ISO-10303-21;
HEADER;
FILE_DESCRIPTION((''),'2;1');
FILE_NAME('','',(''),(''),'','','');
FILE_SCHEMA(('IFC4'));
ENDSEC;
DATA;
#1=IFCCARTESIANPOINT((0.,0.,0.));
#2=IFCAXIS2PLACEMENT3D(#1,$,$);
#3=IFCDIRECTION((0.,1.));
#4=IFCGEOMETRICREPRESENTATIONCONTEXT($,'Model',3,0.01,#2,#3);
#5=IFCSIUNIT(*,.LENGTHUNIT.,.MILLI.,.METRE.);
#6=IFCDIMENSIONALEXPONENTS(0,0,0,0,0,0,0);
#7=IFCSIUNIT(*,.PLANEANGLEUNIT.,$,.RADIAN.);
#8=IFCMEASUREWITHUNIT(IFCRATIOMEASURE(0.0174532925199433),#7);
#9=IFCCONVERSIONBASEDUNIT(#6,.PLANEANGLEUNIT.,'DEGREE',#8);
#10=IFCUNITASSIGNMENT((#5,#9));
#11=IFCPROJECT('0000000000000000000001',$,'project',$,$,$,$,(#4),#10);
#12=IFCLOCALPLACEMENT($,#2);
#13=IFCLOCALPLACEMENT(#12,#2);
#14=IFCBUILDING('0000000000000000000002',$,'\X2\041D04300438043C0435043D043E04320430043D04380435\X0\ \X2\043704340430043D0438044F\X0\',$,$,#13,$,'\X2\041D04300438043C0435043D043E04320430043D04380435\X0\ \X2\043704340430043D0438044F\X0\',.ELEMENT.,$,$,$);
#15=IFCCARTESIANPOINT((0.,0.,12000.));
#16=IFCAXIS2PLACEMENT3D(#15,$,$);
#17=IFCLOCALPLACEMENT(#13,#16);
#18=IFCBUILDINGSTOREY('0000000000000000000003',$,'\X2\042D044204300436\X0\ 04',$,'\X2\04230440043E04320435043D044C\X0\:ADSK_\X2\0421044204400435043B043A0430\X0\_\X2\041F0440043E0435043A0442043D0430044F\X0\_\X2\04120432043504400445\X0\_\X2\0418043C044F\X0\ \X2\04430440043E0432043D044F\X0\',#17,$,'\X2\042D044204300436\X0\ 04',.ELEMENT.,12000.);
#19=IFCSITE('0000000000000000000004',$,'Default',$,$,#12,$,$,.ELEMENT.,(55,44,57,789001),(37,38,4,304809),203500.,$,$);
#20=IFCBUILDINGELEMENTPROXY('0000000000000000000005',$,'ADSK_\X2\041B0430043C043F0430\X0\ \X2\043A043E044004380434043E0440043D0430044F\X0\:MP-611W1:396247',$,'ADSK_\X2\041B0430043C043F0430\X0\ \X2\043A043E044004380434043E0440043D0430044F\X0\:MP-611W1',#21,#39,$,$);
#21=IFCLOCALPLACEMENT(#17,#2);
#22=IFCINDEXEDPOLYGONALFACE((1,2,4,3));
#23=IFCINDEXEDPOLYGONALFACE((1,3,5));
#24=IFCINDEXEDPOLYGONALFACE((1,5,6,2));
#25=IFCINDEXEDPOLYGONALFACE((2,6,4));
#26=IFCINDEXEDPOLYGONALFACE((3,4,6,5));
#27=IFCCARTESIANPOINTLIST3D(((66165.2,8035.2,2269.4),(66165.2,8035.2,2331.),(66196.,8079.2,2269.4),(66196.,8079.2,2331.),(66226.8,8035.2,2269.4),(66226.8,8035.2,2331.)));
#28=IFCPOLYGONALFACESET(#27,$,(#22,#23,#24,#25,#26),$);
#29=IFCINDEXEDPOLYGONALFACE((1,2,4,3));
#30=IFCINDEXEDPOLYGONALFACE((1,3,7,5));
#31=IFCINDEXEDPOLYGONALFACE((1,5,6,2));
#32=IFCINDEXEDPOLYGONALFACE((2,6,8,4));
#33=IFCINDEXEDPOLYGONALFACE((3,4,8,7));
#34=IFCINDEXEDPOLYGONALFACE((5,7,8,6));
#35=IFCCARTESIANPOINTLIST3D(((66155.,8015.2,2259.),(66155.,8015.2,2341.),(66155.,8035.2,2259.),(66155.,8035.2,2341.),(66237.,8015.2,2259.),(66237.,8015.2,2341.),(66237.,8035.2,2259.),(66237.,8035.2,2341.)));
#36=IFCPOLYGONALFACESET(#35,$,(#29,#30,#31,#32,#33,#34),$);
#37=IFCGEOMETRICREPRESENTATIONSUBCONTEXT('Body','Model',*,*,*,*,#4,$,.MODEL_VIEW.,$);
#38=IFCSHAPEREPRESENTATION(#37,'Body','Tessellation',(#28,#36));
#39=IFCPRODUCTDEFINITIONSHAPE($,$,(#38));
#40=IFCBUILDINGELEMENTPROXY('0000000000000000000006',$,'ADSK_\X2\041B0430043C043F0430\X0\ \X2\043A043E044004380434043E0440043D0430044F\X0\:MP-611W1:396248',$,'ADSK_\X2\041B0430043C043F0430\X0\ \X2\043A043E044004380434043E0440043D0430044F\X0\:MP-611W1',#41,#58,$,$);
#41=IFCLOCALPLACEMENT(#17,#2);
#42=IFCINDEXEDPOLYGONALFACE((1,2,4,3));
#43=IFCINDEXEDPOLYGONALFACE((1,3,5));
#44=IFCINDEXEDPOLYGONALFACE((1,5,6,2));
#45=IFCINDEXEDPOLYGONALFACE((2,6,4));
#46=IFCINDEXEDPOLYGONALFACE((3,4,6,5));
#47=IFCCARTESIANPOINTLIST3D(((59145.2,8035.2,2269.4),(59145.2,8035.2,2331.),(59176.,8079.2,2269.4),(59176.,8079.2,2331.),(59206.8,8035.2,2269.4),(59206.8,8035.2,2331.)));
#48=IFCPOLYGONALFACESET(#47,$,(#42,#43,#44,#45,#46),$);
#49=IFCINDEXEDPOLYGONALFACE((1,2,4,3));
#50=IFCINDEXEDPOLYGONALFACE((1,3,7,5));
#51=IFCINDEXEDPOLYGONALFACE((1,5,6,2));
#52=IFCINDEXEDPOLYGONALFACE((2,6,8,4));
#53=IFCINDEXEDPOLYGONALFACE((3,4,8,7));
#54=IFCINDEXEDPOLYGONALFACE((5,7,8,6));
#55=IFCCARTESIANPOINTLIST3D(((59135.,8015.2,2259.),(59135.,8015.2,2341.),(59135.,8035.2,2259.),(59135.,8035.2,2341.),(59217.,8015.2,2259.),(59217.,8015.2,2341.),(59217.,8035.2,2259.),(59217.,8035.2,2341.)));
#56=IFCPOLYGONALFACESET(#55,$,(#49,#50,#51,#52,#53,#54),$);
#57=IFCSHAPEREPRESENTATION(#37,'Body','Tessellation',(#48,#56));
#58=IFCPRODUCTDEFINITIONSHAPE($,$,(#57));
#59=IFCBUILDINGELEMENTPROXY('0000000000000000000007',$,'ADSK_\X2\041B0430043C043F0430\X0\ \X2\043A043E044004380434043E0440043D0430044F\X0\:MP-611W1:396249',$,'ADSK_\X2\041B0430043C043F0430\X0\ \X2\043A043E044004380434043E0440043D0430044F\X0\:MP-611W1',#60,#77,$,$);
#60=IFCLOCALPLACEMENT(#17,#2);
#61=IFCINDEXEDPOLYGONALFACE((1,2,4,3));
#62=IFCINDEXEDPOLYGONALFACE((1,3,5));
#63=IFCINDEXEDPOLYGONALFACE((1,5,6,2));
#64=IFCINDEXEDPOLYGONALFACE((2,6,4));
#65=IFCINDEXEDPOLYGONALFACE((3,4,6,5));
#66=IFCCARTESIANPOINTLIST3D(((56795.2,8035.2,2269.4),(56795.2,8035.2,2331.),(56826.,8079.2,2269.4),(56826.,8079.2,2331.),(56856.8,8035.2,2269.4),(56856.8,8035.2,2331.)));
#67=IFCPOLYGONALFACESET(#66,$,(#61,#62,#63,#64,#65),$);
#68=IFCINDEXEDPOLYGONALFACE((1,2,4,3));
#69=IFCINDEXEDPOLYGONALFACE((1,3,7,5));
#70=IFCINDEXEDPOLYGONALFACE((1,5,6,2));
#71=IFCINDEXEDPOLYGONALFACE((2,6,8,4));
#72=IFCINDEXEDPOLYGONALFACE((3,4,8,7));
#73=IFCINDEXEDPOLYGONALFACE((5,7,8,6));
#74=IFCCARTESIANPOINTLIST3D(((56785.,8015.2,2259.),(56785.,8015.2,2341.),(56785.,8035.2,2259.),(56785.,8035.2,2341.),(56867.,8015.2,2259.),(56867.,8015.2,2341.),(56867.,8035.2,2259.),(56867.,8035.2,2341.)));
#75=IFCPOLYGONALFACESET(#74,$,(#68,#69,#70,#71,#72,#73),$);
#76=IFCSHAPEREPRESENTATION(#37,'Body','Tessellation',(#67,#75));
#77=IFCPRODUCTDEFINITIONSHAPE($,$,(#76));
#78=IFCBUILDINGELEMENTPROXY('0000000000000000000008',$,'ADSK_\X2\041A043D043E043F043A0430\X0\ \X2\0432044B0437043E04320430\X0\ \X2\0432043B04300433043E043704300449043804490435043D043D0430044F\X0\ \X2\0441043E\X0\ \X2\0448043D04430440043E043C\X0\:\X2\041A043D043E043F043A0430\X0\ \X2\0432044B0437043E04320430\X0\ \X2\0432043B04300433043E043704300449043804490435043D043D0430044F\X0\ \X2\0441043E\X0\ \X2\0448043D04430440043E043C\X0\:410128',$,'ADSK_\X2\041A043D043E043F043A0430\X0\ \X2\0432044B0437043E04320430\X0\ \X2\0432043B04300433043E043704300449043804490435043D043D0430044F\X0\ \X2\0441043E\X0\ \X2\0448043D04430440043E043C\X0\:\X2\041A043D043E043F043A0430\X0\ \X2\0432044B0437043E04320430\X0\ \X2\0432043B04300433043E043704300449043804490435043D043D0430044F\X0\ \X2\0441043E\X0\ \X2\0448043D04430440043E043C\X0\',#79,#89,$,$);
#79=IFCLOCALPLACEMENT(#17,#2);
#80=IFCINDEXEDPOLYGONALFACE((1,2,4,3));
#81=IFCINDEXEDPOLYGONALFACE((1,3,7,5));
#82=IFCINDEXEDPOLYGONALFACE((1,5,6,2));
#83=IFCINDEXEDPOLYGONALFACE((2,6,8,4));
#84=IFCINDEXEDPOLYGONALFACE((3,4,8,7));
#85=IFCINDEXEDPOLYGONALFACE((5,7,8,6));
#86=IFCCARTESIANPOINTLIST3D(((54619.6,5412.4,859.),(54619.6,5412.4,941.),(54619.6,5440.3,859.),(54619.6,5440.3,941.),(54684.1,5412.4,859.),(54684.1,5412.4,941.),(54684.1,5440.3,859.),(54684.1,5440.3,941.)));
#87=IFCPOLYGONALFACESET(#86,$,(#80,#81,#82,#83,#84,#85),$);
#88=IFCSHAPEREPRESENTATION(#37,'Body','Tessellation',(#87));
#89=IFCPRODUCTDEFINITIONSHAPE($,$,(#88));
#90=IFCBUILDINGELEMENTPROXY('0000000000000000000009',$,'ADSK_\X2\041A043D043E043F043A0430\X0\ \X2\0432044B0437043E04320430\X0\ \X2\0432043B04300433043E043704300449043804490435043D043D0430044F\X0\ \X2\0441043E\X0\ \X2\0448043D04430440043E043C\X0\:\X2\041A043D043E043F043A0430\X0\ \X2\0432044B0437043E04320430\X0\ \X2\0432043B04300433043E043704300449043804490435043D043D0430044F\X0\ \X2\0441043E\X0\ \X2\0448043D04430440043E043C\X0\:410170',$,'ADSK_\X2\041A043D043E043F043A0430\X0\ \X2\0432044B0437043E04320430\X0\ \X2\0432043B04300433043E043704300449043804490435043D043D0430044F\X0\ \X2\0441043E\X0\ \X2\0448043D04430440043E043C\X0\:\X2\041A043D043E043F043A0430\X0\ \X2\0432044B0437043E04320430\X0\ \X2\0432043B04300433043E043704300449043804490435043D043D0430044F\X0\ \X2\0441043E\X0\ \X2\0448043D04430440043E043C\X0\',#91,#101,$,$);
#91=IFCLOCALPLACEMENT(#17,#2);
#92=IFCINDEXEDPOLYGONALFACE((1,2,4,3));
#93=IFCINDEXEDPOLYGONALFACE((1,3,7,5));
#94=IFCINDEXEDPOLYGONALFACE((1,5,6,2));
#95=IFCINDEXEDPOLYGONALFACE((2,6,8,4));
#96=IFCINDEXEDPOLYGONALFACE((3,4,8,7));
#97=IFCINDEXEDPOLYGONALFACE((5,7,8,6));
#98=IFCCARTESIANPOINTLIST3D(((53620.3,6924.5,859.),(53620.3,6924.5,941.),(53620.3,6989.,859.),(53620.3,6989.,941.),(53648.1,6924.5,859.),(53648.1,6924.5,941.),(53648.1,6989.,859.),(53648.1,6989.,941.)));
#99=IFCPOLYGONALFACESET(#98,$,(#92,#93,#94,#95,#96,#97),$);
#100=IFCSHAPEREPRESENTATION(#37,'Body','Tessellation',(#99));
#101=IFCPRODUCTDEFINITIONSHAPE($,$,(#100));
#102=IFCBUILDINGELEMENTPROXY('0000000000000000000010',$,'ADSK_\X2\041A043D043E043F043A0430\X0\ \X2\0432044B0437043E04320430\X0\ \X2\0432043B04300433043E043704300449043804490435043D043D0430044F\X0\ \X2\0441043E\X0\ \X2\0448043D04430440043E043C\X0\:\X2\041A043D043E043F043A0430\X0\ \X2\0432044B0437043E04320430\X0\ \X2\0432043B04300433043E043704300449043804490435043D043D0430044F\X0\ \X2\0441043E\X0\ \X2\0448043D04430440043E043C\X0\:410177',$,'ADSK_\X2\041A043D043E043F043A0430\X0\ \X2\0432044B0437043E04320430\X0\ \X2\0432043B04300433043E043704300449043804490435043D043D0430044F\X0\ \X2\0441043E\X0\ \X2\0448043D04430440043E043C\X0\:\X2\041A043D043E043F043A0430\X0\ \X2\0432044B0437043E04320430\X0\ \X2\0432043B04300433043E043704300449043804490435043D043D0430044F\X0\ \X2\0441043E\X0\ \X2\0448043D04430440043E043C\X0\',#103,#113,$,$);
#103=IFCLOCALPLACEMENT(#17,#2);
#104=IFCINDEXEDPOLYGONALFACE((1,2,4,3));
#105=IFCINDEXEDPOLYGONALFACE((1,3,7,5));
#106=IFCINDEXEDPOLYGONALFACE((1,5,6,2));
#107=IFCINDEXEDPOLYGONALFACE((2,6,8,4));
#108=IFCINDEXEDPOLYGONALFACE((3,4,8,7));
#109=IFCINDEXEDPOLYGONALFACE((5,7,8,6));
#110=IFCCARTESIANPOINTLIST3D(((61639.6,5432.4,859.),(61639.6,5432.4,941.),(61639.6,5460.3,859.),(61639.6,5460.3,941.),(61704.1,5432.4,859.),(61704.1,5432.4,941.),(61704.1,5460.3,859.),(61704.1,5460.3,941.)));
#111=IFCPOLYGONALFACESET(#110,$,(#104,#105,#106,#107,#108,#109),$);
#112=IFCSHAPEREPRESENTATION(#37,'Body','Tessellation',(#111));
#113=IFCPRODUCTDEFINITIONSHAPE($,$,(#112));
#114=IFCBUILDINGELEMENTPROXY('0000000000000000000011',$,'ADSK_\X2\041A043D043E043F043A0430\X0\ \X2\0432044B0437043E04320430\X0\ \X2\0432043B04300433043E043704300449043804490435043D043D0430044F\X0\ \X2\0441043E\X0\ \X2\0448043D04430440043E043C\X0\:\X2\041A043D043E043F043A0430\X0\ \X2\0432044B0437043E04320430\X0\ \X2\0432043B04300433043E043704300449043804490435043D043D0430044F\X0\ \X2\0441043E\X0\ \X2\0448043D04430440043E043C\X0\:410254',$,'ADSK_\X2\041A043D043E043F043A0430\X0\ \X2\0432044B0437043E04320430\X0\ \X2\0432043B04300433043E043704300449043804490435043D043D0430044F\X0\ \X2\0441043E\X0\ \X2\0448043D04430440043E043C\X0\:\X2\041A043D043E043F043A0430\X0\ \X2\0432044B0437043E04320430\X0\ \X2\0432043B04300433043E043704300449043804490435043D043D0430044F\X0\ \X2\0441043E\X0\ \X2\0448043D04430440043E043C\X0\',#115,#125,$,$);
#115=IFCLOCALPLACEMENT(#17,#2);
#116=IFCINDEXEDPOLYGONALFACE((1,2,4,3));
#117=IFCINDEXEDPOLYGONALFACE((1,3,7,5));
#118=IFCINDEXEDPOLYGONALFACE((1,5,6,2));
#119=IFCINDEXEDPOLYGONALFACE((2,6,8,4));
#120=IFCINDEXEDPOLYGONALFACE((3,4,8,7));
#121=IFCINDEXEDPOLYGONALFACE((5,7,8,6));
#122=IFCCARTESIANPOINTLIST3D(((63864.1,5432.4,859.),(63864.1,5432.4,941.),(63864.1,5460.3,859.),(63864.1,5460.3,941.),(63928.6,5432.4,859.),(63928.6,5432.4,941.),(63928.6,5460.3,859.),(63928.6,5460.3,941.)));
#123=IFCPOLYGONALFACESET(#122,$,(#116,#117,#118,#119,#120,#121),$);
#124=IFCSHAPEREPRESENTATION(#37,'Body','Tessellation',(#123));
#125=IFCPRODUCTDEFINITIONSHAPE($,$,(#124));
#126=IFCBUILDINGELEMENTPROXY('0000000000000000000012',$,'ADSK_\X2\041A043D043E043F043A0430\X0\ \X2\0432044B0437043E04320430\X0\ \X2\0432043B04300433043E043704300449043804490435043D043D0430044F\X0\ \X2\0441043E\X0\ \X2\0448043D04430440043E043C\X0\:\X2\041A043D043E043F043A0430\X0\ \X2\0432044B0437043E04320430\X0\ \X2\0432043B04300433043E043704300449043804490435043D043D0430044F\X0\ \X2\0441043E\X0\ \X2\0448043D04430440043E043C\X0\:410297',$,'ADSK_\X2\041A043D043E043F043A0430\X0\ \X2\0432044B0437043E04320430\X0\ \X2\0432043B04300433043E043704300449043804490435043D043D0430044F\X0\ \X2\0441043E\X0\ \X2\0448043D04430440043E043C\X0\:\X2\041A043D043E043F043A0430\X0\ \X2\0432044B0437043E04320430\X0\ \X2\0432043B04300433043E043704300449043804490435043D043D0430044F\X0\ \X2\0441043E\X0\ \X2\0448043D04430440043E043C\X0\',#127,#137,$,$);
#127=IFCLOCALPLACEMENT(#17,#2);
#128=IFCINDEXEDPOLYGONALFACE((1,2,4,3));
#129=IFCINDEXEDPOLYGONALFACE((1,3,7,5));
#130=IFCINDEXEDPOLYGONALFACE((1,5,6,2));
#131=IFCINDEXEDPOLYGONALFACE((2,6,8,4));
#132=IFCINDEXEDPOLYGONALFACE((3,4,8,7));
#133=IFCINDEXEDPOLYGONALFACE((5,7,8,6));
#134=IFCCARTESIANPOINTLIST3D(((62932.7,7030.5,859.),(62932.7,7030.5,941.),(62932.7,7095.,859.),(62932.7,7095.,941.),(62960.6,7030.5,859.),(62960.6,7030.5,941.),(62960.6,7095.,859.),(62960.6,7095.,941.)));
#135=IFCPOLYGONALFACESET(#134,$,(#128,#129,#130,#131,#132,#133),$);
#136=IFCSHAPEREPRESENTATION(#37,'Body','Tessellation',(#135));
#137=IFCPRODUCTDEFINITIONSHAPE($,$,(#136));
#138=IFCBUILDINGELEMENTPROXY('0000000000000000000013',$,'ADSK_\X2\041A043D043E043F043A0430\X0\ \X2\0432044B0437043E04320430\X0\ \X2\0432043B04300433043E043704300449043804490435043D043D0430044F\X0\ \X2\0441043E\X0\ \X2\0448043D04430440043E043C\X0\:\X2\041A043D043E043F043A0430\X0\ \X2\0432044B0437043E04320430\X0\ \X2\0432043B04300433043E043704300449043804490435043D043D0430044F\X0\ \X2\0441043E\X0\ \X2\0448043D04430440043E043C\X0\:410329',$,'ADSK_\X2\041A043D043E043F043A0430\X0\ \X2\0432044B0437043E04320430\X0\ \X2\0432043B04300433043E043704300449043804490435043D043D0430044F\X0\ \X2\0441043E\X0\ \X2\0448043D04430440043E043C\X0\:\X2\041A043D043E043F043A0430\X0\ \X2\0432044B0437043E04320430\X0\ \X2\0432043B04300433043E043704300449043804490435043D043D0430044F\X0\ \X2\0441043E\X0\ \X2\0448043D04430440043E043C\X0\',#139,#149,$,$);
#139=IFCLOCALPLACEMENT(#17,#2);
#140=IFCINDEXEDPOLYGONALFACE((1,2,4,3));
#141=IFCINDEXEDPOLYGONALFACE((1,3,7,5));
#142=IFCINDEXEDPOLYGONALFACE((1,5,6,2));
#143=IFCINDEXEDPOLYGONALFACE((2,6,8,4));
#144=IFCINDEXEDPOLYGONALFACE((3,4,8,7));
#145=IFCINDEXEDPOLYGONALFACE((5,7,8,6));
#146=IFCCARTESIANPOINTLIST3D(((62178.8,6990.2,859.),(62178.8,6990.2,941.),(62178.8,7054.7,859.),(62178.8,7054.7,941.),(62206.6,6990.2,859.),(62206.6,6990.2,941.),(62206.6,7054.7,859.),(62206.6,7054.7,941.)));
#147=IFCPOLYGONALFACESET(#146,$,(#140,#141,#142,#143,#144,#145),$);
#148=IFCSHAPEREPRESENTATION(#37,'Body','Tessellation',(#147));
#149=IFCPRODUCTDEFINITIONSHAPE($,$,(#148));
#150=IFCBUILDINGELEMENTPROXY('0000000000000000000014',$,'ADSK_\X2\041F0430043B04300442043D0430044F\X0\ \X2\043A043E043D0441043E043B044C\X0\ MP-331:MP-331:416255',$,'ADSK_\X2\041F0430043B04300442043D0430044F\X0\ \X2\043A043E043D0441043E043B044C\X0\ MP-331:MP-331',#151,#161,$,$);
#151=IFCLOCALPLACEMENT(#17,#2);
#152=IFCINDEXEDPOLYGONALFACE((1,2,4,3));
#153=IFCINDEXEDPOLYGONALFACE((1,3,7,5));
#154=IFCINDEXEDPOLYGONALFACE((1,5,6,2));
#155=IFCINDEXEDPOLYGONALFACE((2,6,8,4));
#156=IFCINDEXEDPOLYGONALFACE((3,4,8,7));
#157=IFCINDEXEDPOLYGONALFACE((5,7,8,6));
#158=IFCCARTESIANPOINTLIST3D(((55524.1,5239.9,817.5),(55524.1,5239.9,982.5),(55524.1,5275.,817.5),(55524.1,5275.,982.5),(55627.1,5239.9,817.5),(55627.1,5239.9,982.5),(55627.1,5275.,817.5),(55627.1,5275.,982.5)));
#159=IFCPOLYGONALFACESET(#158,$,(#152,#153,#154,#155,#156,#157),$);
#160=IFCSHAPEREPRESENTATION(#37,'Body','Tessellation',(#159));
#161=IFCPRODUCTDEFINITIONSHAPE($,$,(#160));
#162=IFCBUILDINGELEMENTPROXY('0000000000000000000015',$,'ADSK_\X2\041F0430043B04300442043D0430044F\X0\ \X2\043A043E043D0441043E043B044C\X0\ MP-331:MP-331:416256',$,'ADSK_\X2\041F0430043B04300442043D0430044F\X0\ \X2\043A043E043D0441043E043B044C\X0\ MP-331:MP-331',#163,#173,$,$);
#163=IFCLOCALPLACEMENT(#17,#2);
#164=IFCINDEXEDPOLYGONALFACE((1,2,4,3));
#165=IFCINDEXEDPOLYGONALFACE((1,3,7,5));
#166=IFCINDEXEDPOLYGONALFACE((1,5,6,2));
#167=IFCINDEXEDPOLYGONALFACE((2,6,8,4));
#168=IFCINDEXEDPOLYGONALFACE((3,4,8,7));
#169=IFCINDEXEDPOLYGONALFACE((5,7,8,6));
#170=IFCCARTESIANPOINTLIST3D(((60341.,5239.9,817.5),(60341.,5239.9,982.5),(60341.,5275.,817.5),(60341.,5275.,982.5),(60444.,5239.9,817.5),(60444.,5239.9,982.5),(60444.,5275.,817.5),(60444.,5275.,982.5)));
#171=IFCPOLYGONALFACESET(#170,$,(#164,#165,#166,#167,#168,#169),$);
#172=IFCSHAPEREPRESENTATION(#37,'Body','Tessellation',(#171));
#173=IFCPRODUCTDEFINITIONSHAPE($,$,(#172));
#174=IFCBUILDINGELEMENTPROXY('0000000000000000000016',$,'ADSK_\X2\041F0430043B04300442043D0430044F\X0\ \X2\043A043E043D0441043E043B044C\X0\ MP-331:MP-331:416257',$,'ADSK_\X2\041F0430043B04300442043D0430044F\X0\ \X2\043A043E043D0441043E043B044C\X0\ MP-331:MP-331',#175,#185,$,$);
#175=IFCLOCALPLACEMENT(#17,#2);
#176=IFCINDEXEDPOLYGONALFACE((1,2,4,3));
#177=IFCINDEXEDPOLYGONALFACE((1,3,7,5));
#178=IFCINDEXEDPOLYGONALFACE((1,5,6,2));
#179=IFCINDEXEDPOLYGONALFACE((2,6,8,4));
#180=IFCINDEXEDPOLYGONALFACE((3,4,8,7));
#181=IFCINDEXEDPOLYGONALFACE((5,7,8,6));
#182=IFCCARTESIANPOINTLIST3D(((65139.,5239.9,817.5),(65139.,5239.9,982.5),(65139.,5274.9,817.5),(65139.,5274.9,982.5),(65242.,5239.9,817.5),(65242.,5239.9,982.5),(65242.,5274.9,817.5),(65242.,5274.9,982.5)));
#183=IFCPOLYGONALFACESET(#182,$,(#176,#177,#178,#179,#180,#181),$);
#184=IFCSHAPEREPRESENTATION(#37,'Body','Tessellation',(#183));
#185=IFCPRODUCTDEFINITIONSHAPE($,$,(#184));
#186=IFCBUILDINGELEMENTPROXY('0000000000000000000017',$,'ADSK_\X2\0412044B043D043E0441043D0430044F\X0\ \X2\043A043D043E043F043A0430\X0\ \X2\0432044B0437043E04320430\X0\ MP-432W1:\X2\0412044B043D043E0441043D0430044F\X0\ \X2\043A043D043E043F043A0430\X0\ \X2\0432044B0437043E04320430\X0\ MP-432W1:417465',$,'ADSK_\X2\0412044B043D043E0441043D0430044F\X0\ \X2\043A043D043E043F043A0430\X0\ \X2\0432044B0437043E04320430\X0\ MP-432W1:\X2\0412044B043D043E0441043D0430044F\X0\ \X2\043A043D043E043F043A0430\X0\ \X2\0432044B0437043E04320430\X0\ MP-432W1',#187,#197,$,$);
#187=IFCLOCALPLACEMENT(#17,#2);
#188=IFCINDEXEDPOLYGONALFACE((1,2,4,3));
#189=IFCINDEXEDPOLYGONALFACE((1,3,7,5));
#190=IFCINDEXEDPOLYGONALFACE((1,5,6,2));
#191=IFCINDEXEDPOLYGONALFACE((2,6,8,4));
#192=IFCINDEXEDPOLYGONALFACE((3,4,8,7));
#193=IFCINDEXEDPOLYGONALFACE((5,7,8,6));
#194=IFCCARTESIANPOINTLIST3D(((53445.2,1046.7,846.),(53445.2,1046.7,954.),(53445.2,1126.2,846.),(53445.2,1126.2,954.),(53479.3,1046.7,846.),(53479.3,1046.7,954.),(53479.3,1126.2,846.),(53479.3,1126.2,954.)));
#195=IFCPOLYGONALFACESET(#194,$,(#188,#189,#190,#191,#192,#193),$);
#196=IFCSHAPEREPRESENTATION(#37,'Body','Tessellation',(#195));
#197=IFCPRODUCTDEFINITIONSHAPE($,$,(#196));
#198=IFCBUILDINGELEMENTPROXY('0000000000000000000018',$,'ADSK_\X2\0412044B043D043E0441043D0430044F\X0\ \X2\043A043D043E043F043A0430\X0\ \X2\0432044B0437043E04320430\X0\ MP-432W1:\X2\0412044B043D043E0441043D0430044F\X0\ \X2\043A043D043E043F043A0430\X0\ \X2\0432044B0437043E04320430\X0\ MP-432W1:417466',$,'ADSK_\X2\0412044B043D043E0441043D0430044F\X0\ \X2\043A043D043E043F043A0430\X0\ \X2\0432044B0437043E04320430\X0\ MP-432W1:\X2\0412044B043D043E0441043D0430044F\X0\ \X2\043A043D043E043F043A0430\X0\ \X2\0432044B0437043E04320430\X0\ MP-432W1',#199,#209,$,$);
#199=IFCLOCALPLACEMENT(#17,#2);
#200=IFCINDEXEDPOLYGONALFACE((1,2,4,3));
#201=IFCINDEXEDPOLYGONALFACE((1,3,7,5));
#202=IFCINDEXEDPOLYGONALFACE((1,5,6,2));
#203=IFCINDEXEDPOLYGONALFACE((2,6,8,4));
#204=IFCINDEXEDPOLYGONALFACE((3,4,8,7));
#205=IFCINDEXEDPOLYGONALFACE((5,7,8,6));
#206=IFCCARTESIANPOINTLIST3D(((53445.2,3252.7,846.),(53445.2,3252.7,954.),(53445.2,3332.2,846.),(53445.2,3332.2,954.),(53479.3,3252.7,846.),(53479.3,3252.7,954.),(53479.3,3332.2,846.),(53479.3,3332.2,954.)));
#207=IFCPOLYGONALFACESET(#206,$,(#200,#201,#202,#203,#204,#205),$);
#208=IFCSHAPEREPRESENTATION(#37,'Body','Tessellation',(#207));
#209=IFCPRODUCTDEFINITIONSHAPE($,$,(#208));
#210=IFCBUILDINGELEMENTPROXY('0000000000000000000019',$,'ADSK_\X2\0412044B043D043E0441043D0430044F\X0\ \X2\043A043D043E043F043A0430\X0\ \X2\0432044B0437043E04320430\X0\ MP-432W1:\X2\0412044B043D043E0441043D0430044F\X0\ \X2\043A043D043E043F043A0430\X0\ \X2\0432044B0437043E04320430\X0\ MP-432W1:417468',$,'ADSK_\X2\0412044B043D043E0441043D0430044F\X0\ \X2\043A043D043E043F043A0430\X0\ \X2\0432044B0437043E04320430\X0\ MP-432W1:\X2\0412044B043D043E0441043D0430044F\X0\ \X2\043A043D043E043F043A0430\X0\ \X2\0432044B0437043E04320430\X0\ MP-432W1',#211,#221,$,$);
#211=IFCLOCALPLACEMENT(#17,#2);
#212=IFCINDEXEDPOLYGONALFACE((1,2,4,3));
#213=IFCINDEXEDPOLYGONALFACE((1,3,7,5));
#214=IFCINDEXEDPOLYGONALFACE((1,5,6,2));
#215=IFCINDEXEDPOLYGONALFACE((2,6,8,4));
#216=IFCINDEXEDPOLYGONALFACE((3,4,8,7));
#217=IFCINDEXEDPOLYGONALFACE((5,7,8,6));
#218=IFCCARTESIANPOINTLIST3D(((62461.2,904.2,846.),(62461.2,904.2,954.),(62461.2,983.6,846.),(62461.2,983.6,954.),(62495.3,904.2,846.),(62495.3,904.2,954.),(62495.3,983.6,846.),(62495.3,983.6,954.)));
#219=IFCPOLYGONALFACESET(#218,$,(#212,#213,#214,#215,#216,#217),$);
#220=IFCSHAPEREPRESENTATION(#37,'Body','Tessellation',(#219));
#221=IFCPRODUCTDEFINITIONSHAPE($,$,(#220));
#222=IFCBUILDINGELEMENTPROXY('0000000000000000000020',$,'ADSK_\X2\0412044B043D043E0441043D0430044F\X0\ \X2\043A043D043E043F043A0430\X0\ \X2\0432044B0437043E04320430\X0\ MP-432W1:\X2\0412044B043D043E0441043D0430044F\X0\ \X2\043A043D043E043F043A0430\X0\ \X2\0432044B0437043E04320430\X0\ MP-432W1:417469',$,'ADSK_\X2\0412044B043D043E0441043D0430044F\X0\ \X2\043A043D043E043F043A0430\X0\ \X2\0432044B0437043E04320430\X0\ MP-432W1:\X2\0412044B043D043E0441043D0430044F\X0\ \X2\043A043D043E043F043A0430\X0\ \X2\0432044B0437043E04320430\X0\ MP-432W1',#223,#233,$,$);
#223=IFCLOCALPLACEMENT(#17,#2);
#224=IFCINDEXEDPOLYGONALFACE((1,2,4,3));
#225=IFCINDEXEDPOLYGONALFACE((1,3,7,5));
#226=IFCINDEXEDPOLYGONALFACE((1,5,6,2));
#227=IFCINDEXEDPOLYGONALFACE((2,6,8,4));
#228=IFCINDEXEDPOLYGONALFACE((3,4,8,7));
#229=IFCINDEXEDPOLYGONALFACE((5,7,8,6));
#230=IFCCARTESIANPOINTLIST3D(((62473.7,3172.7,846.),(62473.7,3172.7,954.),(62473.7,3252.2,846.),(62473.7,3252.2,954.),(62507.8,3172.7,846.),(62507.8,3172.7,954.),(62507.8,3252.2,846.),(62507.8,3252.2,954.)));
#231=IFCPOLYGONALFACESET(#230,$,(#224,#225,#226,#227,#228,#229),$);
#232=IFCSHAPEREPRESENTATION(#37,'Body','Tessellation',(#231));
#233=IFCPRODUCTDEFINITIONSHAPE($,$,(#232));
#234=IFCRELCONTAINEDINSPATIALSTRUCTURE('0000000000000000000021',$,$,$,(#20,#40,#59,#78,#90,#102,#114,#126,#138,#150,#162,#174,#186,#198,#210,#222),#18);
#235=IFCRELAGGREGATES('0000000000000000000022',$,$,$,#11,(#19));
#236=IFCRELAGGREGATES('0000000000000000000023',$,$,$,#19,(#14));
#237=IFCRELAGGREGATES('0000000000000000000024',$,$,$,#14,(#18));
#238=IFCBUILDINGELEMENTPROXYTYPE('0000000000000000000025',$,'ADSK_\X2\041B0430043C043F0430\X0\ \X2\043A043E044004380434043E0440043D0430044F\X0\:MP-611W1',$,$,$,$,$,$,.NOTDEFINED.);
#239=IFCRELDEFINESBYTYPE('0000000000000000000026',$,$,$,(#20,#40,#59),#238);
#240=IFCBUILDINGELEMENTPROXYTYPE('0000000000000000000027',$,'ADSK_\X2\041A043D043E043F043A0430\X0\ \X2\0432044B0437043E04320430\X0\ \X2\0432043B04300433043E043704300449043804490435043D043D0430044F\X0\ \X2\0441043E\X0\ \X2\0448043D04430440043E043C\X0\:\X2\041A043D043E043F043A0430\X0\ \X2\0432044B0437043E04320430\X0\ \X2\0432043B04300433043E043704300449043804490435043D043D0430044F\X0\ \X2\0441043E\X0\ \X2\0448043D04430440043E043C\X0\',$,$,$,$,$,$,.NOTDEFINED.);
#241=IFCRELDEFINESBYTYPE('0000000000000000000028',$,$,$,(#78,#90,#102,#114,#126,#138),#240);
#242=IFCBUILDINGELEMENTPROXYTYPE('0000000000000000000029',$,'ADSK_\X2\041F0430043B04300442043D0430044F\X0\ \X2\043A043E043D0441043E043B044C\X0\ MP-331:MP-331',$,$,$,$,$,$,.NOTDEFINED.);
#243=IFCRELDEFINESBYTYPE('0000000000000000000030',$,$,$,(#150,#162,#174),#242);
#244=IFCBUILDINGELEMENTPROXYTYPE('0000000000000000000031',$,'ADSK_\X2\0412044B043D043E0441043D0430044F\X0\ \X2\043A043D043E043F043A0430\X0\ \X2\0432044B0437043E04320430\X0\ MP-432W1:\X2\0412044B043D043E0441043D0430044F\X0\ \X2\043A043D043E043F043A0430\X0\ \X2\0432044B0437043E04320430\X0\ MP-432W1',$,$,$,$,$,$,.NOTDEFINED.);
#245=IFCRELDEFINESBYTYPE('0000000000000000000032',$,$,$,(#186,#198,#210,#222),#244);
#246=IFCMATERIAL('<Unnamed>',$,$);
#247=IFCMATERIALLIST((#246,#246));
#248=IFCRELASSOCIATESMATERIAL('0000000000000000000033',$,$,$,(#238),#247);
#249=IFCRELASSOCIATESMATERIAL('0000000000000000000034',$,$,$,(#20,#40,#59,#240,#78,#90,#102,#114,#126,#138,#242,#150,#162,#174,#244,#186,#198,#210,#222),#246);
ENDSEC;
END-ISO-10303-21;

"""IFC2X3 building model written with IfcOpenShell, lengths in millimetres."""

from ifc_helpers import new_model, entity, si_unit, converted_unit, direction, frame, origin, origin_2d_with_axis, place, context, subcontext, project, spatial, polyline, rectangle, outline, extrude, source, transform, mapped, material, material_list, type_object, type_shapes, element, save


model = new_model("IFC2X3")

# Units and contexts
model_context = context("Model", 3, precision=0.01, world=origin(), true_north=direction((0.0, 1.0)))
body_context = subcontext(model_context, "Body", "Model", "MODEL_VIEW")
ifc_project = project(units=[si_unit("LENGTHUNIT", "METRE", prefix="MILLI"), converted_unit("PLANEANGLEUNIT", "DEGREE", entity("IfcRatioMeasure", 0.0174532925199433), si_unit("PLANEANGLEUNIT", "RADIAN"), dimensions=[0, 0, 0, 0, 0, 0, 0])], contexts=[model_context])

# Site, building, storey
site_placement = place(None, origin())
site = spatial("IfcSite", under=ifc_project, at=site_placement, Name="Default", CompositionType="ELEMENT", RefLatitude=(55, 44, 57, 789001), RefLongitude=(37, 38, 4, 304809), RefElevation=203500.0)
building_placement = place(site_placement, origin())
building = spatial("IfcBuilding", under=site, at=building_placement, Name="Наименование здания", LongName="Наименование здания", CompositionType="ELEMENT")
storey_placement = place(building_placement, frame((0.0, 0.0, 12000.0)))
storey = spatial("IfcBuildingStorey", under=building, at=storey_placement, Name="Этаж 04", ObjectType="Уровень:ADSK_Стрелка_Проектная_Вверх_Имя уровня", LongName="Этаж 04", CompositionType="ELEMENT", Elevation=12000.0)

# Building element proxies
ifc_material = material(Name="<Unnamed>")
ifc_material_list = material_list([ifc_material, ifc_material])
building_element_proxy_type_1 = type_object("IfcBuildingElementProxyType", Name="ADSK_Лампа коридорная:MP-611W1", PredefinedType="NOTDEFINED", material=ifc_material_list)
shared_shape_1 = source(origin(), body_context, "Body", "SweptSolid", [
    extrude(outline(polyline([(-30.8, -14.7), (30.8, -14.7), (0.0, 29.3), (-30.8, -14.7)])), frame((0.0, -2.7, -30.6), z_axis=(0.0, 0.0, 1.0), x_axis=(-1.0, 0.0, 0.0)), (0.0, 0.0, 1.0), 61.6),
    extrude(rectangle(XDim=82.0, YDim=20.0, at=origin_2d_with_axis()), frame((0.0, 22.0, -41.0), z_axis=(0.0, 0.0, 1.0), x_axis=(-1.0, 0.0, 0.0)), (0.0, 0.0, 1.0), 82.0),
])
type_shapes(building_element_proxy_type_1, [shared_shape_1])
for number, where, z_axis, x_axis, name in (
    (1, (66196.0, 8047.1, 2300.0), (0.0, 0.0, 1.0), (-1.0, 0.0, 0.0), "ADSK_Лампа коридорная:MP-611W1:396247"),
    (2, (59176.0, 8047.1, 2300.0), (0.0, 0.0, 1.0), (-1.0, 0.0, 0.0), "ADSK_Лампа коридорная:MP-611W1:396248"),
    (3, (56826.0, 8047.1, 2300.0), (0.0, 0.0, 1.0), (-1.0, 0.0, 0.0), "ADSK_Лампа коридорная:MP-611W1:396249"),
):
    element("IfcBuildingElementProxy", number, at=place(storey_placement, frame(where, z_axis=z_axis, x_axis=x_axis)), inside=storey, type_object=building_element_proxy_type_1, material=ifc_material, Name=name, ObjectType="ADSK_Лампа коридорная:MP-611W1", context=body_context, shape_type="MappedRepresentation", body=[
        mapped(shared_shape_1, transform((0.0, 0.0, 0.0), scale=1.0)),
    ])
building_element_proxy_type_2 = type_object("IfcBuildingElementProxyType", Name="ADSK_Кнопка вызова влагозащищенная со шнуром:Кнопка вызова влагозащищенная со шнуром", PredefinedType="NOTDEFINED", material=ifc_material)
shared_shape_2 = source(origin(), body_context, "Body", "SweptSolid", [
    extrude(rectangle(XDim=64.5, YDim=27.8, at=origin_2d_with_axis()), frame((32.2, 13.9, 0.0), z_axis=(0.0, 0.0, 1.0), x_axis=(-1.0, 0.0, 0.0)), (0.0, 0.0, 1.0), 82.0),
])
type_shapes(building_element_proxy_type_2, [shared_shape_2])
for number, where, z_axis, x_axis, name in (
    (4, (54684.1, 5440.3, 859.0), (0.0, 0.0, 1.0), (-1.0, 0.0, 0.0), "ADSK_Кнопка вызова влагозащищенная со шнуром:Кнопка вызова влагозащищенная со шнуром:410128"),
    (5, (53648.1, 6924.5, 859.0), (0.0, 0.0, 1.0), (0.0, 1.0, 0.0), "ADSK_Кнопка вызова влагозащищенная со шнуром:Кнопка вызова влагозащищенная со шнуром:410170"),
    (6, (61704.1, 5460.3, 859.0), (0.0, 0.0, 1.0), (-1.0, 0.0, 0.0), "ADSK_Кнопка вызова влагозащищенная со шнуром:Кнопка вызова влагозащищенная со шнуром:410177"),
    (7, (63928.6, 5460.3, 859.0), (0.0, 0.0, 1.0), (-1.0, 0.0, 0.0), "ADSK_Кнопка вызова влагозащищенная со шнуром:Кнопка вызова влагозащищенная со шнуром:410254"),
    (8, (62960.6, 7030.5, 859.0), (0.0, 0.0, 1.0), (0.0, 1.0, 0.0), "ADSK_Кнопка вызова влагозащищенная со шнуром:Кнопка вызова влагозащищенная со шнуром:410297"),
    (9, (62178.8, 7054.7, 859.0), (0.0, 0.0, 1.0), (0.0, -1.0, 0.0), "ADSK_Кнопка вызова влагозащищенная со шнуром:Кнопка вызова влагозащищенная со шнуром:410329"),
):
    element("IfcBuildingElementProxy", number, at=place(storey_placement, frame(where, z_axis=z_axis, x_axis=x_axis)), inside=storey, type_object=building_element_proxy_type_2, material=ifc_material, Name=name, ObjectType="ADSK_Кнопка вызова влагозащищенная со шнуром:Кнопка вызова влагозащищенная со шнуром", context=body_context, shape_type="MappedRepresentation", body=[
        mapped(shared_shape_2, transform((0.0, 0.0, 0.0), scale=1.0)),
    ])
building_element_proxy_type_3 = type_object("IfcBuildingElementProxyType", Name="ADSK_Палатная консоль MP-331:MP-331", PredefinedType="NOTDEFINED", material=ifc_material)
shared_shape_3 = source(origin(), body_context, "Body", "SweptSolid", [
    extrude(rectangle(XDim=103.0, YDim=35.0, at=origin_2d_with_axis()), frame((0.0, 14.5, -82.5), z_axis=(0.0, 0.0, 1.0), x_axis=(-1.0, 0.0, 0.0)), (0.0, 0.0, 1.0), 165.0),
])
type_shapes(building_element_proxy_type_3, [shared_shape_3])
for number, where, name in (
    (10, (55575.6, 5242.9, 900.0), "ADSK_Палатная консоль MP-331:MP-331:416255"),
    (11, (60392.5, 5242.9, 900.0), "ADSK_Палатная консоль MP-331:MP-331:416256"),
    (12, (65190.5, 5242.9, 900.0), "ADSK_Палатная консоль MP-331:MP-331:416257"),
):
    element("IfcBuildingElementProxy", number, at=place(storey_placement, frame(where)), inside=storey, type_object=building_element_proxy_type_3, material=ifc_material, Name=name, ObjectType="ADSK_Палатная консоль MP-331:MP-331", context=body_context, shape_type="MappedRepresentation", body=[
        mapped(shared_shape_3, transform((0.0, 0.0, 0.0), scale=1.0)),
    ])
building_element_proxy_type_4 = type_object("IfcBuildingElementProxyType", Name="ADSK_Выносная кнопка вызова MP-432W1:Выносная кнопка вызова MP-432W1", PredefinedType="NOTDEFINED", material=ifc_material)
shared_shape_4 = source(origin(), body_context, "Body", "SweptSolid", [
    extrude(rectangle(XDim=79.5, YDim=34.1, at=origin_2d_with_axis()), frame((0.0, 15.0, -54.0), z_axis=(0.0, 0.0, 1.0), x_axis=(-1.0, 0.0, 0.0)), (0.0, 0.0, 1.0), 108.0),
])
type_shapes(building_element_proxy_type_4, [shared_shape_4])
for number, where, z_axis, x_axis, name in (
    (13, (53477.2, 1086.5, 900.0), (0.0, 0.0, 1.0), (0.0, 1.0, 0.0), "ADSK_Выносная кнопка вызова MP-432W1:Выносная кнопка вызова MP-432W1:417465"),
    (14, (53477.2, 3292.4, 900.0), (0.0, 0.0, 1.0), (0.0, 1.0, 0.0), "ADSK_Выносная кнопка вызова MP-432W1:Выносная кнопка вызова MP-432W1:417466"),
    (15, (62463.2, 943.9, 900.0), (0.0, 0.0, 1.0), (0.0, -1.0, 0.0), "ADSK_Выносная кнопка вызова MP-432W1:Выносная кнопка вызова MP-432W1:417468"),
    (16, (62475.8, 3212.5, 900.0), (0.0, 0.0, 1.0), (0.0, -1.0, 0.0), "ADSK_Выносная кнопка вызова MP-432W1:Выносная кнопка вызова MP-432W1:417469"),
):
    element("IfcBuildingElementProxy", number, at=place(storey_placement, frame(where, z_axis=z_axis, x_axis=x_axis)), inside=storey, type_object=building_element_proxy_type_4, material=ifc_material, Name=name, ObjectType="ADSK_Выносная кнопка вызова MP-432W1:Выносная кнопка вызова MP-432W1", context=body_context, shape_type="MappedRepresentation", body=[
        mapped(shared_shape_4, transform((0.0, 0.0, 0.0), scale=1.0)),
    ])

save(model, "model.ifc")
